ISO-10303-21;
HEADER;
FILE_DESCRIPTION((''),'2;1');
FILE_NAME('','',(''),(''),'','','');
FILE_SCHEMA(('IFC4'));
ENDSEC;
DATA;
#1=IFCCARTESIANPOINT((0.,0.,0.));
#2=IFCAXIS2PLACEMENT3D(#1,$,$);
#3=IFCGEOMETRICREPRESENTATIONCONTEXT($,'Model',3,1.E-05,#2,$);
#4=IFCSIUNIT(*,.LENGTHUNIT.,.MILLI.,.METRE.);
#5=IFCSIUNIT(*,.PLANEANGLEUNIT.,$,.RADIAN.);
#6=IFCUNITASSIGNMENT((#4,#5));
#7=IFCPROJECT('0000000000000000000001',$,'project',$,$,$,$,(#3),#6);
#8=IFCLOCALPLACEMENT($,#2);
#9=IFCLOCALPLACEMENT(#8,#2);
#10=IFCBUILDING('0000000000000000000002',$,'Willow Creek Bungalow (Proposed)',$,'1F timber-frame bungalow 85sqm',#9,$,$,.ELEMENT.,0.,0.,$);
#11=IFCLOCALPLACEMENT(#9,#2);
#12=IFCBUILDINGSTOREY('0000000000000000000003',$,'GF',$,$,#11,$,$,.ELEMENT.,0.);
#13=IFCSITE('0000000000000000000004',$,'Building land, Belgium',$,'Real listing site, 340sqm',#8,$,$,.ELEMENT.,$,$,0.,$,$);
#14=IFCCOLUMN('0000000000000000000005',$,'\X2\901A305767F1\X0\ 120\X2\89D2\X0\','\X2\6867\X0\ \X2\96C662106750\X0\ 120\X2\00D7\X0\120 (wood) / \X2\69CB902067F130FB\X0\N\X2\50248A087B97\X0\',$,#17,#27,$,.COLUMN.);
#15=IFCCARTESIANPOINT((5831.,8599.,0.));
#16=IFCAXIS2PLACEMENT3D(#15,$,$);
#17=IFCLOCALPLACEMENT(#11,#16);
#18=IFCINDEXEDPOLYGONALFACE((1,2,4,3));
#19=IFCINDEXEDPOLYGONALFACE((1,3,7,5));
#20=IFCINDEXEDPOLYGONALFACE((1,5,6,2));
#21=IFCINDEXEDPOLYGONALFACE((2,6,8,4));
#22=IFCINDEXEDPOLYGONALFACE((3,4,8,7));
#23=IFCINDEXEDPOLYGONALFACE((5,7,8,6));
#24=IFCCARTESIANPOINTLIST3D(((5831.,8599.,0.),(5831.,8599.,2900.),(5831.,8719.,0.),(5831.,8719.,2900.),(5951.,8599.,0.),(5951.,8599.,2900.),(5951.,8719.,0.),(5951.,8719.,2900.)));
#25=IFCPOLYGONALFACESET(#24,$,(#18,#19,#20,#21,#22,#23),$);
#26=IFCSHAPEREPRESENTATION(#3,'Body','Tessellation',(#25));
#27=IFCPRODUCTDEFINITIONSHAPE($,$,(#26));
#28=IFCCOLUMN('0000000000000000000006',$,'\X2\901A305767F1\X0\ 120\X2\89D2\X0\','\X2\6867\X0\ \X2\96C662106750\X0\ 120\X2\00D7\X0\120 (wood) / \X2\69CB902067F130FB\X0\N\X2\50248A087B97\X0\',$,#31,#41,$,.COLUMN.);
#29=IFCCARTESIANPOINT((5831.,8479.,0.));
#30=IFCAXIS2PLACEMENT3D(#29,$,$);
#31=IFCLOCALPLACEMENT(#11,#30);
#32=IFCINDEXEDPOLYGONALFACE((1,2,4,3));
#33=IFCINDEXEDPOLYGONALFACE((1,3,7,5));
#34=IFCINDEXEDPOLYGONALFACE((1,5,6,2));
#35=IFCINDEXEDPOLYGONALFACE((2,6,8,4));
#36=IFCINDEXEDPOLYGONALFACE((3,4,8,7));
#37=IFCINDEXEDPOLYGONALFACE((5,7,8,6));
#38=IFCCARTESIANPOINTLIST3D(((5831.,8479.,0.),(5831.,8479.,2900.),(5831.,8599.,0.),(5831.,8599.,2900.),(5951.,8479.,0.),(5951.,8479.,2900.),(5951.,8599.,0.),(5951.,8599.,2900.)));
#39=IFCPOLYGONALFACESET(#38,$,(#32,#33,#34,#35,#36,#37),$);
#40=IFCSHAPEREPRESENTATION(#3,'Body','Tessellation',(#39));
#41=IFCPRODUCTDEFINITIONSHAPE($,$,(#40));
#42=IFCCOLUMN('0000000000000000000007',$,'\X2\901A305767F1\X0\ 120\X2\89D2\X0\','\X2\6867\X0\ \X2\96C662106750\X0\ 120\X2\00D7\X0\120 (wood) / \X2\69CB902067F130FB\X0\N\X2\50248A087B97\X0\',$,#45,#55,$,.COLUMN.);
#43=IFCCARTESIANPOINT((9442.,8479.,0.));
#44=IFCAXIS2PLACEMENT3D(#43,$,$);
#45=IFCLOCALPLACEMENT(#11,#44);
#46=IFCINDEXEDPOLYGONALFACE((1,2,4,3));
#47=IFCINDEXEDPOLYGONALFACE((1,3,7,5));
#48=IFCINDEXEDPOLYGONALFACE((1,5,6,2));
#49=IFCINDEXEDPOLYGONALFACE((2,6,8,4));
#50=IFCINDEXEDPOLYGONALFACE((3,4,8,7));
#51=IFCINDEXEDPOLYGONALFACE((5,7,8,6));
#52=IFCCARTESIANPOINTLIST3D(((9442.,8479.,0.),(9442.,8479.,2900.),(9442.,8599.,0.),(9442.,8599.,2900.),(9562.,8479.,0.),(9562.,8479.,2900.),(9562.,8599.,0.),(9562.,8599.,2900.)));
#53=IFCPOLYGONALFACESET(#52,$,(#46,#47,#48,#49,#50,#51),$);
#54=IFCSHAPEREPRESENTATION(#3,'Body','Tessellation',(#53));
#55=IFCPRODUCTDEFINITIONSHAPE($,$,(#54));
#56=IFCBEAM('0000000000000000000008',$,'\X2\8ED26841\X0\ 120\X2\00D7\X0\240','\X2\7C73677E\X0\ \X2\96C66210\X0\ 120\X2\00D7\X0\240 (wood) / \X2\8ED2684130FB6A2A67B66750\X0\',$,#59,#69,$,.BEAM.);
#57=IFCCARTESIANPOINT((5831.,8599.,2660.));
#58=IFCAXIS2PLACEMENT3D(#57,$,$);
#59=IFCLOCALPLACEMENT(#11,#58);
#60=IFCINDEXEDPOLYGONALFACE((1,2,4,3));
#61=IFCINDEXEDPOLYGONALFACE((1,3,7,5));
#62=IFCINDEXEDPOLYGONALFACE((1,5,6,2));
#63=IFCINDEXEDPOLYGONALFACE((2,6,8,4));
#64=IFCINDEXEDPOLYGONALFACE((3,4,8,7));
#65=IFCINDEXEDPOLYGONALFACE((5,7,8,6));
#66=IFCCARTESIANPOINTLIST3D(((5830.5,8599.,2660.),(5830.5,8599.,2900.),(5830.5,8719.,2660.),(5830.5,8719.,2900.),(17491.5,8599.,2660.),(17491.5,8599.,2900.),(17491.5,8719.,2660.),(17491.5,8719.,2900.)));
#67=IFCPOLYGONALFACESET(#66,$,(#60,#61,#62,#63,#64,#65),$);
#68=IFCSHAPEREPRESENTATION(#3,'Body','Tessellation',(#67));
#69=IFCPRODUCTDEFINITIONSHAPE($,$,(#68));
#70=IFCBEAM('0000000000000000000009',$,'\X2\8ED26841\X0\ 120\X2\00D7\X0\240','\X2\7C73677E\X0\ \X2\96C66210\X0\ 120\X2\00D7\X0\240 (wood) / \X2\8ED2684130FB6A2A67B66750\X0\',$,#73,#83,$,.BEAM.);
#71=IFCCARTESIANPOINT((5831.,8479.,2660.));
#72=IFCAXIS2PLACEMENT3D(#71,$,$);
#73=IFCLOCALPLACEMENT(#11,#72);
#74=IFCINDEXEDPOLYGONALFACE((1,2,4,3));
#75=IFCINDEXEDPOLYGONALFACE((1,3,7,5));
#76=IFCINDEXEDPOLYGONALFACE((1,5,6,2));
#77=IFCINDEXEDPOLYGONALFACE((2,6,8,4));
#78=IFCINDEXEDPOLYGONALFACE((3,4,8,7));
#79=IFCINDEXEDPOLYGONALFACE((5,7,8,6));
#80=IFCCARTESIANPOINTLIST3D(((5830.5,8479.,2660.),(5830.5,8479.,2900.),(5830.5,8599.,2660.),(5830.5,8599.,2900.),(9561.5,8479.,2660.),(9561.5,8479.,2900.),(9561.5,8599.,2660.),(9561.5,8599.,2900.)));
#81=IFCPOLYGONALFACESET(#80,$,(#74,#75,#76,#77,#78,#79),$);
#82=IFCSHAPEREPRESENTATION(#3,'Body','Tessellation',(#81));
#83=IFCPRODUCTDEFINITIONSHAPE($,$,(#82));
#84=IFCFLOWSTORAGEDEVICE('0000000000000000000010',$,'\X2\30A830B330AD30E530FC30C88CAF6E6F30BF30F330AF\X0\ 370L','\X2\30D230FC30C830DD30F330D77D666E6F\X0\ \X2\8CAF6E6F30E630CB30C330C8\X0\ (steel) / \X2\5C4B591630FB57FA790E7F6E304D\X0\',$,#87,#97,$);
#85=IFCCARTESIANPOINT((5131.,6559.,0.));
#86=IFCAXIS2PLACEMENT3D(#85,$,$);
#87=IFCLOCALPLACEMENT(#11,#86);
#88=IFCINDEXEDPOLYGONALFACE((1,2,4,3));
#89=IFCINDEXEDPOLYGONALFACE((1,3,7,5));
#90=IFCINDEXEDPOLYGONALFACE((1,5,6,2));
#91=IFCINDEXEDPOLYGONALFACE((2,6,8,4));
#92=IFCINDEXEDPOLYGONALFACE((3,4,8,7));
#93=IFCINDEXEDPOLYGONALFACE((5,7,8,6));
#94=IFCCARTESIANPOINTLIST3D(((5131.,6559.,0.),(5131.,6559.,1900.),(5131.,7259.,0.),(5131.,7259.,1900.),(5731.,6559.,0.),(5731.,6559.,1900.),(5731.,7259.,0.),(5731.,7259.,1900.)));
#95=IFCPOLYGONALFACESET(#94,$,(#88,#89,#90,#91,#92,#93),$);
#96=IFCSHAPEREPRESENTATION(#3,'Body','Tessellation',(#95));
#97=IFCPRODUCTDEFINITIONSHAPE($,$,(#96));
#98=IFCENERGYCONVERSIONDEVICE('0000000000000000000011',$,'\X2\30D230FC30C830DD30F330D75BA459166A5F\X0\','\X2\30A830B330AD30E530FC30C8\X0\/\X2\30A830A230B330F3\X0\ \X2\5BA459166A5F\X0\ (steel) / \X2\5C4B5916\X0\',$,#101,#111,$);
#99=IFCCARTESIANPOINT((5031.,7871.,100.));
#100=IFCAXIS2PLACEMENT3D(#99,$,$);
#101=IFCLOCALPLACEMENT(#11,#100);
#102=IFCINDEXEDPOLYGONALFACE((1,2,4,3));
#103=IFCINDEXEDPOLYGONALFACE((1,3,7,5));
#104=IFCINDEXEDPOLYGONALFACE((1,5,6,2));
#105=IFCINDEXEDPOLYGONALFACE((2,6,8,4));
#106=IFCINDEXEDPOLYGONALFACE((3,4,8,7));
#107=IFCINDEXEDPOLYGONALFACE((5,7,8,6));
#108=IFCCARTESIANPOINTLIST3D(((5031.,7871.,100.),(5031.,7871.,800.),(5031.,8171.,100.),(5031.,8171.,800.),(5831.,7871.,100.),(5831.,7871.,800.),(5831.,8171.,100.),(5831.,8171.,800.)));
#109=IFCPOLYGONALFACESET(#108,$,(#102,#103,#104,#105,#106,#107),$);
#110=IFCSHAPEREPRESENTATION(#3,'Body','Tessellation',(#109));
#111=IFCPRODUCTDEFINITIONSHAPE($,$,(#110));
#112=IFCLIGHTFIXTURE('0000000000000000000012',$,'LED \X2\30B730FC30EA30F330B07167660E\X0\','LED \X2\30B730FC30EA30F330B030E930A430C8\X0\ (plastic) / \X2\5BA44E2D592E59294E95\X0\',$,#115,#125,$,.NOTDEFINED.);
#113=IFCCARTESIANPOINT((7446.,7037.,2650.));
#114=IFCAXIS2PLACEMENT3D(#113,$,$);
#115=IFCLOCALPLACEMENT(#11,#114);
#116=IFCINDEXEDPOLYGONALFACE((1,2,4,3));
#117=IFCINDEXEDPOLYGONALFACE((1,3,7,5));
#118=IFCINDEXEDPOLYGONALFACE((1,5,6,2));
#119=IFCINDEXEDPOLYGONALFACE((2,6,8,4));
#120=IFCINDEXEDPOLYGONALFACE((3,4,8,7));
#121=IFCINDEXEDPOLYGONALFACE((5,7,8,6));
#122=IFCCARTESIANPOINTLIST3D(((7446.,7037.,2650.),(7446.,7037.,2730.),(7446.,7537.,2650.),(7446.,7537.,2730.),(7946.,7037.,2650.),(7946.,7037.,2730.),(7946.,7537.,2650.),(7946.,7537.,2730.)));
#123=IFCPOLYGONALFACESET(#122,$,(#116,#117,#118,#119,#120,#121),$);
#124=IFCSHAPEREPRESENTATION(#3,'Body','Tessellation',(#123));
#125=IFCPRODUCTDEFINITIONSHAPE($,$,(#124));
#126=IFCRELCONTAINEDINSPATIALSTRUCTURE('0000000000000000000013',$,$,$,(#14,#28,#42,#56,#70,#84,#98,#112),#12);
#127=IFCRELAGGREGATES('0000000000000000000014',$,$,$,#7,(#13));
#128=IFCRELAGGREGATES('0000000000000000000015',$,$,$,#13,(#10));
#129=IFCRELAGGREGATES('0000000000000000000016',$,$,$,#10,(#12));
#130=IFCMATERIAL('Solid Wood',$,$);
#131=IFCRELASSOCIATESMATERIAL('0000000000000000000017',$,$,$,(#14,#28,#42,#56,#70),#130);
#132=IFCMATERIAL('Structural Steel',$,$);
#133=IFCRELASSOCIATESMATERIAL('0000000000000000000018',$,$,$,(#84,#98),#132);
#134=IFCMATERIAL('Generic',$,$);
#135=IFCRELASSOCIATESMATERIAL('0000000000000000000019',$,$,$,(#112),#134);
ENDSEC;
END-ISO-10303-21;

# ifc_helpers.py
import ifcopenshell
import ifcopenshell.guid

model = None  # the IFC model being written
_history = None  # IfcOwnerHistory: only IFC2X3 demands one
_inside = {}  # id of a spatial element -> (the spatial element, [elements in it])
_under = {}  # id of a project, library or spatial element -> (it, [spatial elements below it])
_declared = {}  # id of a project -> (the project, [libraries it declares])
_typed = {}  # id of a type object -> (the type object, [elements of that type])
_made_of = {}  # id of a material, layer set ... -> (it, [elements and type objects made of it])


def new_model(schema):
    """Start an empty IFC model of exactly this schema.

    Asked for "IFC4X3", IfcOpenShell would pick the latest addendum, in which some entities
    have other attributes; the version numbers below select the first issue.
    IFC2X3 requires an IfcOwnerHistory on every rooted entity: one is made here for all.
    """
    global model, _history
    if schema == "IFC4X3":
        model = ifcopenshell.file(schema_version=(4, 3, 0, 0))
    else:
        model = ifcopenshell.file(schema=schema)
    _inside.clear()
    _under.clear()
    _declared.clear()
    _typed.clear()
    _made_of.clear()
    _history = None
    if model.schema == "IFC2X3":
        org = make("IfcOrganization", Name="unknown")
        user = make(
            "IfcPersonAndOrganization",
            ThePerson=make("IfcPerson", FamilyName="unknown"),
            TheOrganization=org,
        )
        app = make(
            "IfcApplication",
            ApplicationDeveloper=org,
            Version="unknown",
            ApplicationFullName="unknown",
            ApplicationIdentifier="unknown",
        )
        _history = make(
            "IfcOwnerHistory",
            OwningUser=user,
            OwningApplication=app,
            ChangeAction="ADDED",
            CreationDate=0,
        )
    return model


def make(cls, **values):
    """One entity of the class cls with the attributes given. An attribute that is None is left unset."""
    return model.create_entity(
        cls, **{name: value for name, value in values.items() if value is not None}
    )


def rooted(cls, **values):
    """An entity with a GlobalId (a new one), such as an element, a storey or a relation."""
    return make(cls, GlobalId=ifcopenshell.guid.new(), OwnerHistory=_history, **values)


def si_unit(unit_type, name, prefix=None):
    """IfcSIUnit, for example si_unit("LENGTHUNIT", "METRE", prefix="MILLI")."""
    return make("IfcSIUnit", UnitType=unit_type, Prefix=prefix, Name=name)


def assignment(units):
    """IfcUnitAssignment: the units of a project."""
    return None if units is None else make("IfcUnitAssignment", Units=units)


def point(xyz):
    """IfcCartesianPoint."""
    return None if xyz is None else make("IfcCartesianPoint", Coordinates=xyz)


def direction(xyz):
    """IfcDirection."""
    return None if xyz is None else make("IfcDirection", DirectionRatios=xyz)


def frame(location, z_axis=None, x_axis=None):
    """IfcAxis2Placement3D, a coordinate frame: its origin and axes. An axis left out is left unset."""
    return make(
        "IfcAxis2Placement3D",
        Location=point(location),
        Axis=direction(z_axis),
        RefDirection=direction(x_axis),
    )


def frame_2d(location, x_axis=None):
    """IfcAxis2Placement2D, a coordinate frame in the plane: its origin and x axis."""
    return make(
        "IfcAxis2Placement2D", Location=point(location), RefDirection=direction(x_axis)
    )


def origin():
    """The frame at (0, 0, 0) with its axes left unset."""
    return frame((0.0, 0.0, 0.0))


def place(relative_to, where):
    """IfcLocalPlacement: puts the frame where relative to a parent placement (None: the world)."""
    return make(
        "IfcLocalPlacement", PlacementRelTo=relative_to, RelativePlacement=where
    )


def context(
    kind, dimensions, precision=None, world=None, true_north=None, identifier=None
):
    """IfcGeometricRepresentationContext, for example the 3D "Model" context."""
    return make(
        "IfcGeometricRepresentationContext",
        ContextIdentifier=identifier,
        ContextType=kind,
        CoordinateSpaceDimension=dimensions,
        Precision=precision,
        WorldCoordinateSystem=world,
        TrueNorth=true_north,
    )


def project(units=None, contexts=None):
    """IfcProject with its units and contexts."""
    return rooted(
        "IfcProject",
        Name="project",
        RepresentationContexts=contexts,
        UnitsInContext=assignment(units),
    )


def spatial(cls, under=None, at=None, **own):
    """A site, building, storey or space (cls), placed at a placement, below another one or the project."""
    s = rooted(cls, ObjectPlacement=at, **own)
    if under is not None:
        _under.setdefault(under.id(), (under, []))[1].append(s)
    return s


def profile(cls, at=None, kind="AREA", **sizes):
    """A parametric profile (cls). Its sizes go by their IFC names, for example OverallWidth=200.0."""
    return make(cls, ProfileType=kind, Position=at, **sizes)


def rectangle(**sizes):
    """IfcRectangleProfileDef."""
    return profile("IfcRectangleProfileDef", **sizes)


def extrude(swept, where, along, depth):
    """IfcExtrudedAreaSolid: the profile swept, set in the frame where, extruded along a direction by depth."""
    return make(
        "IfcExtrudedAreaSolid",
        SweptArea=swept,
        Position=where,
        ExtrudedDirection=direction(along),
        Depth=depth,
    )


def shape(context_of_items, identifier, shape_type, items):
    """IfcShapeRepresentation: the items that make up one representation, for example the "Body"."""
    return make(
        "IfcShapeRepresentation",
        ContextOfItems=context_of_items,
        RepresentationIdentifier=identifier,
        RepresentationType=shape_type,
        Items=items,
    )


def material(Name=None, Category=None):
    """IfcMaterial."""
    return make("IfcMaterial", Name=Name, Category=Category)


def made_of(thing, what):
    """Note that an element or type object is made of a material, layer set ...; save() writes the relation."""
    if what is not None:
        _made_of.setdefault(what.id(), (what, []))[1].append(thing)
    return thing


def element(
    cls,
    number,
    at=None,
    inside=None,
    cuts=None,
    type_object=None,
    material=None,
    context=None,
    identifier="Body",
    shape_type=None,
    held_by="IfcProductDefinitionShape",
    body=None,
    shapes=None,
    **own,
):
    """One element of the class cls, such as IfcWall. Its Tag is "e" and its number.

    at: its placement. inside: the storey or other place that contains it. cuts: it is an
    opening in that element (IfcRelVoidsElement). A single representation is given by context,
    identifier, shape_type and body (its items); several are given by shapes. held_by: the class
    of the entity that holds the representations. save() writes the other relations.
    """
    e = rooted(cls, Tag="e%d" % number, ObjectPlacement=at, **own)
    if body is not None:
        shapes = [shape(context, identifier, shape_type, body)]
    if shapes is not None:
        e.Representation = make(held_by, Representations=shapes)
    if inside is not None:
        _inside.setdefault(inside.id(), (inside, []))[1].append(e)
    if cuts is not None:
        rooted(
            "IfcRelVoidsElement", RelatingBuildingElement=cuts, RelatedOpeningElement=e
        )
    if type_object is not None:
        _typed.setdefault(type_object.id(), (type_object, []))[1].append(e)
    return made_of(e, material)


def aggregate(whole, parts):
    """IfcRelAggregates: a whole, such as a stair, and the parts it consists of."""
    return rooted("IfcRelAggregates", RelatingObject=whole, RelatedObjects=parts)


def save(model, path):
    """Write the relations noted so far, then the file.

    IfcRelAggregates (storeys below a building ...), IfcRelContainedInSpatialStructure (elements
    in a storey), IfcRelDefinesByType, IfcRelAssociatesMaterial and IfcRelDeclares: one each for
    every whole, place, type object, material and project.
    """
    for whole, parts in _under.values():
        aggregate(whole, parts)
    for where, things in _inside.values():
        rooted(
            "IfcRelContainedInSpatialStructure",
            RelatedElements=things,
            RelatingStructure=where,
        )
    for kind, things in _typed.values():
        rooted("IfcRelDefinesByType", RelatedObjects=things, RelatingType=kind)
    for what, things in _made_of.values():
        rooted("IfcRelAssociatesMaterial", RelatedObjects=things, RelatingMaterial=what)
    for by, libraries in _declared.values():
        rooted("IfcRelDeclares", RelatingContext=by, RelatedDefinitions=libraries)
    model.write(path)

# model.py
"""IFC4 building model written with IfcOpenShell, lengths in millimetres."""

from ifc_helpers import new_model, si_unit, frame, frame_2d, origin, place, context, project, spatial, rectangle, extrude, material, element, save


model = new_model("IFC4")

# Units and contexts
model_context = context("Model", 3, precision=1e-05, world=origin())
ifc_project = project(units=[si_unit("LENGTHUNIT", "METRE", prefix="MILLI"), si_unit("PLANEANGLEUNIT", "RADIAN")], contexts=[model_context])

# Site, building, storey
site_placement = place(None, origin())
site = spatial("IfcSite", under=ifc_project, at=site_placement, Name="Building land, Belgium", ObjectType="Real listing site, 340sqm", CompositionType="ELEMENT", RefElevation=0.0)
building_placement = place(site_placement, origin())
building = spatial("IfcBuilding", under=site, at=building_placement, Name="Willow Creek Bungalow (Proposed)", ObjectType="1F timber-frame bungalow 85sqm", CompositionType="ELEMENT", ElevationOfRefHeight=0.0, ElevationOfTerrain=0.0)
storey_placement = place(building_placement, origin())
storey = spatial("IfcBuildingStorey", under=building, at=storey_placement, Name="GF", CompositionType="ELEMENT", Elevation=0.0)

# Columns
ifc_material_1 = material(Name="Solid Wood")
column_1_placement = place(storey_placement, frame((5831.0, 8599.0, 0.0)))
element("IfcColumn", 1, at=column_1_placement, inside=storey, material=ifc_material_1, Name="通し柱 120角", Description="桧 集成材 120×120 (wood) / 構造柱・N値計算", PredefinedType="COLUMN", context=model_context, shape_type="SweptSolid", body=[
    extrude(rectangle(XDim=120.0, YDim=120.0, at=frame_2d((60.0, 60.0))), frame((5831.0, 8599.0, 0.0)), (0.0, 0.0, 1.0), 2900.0),
])
column_2_placement = place(storey_placement, frame((5831.0, 8479.0, 0.0)))
element("IfcColumn", 2, at=column_2_placement, inside=storey, material=ifc_material_1, Name="通し柱 120角", Description="桧 集成材 120×120 (wood) / 構造柱・N値計算", PredefinedType="COLUMN", context=model_context, shape_type="SweptSolid", body=[
    extrude(rectangle(XDim=120.0, YDim=120.0, at=frame_2d((60.0, 60.0))), frame((5831.0, 8479.0, 0.0)), (0.0, 0.0, 1.0), 2900.0),
])
column_3_placement = place(storey_placement, frame((9442.0, 8479.0, 0.0)))
element("IfcColumn", 3, at=column_3_placement, inside=storey, material=ifc_material_1, Name="通し柱 120角", Description="桧 集成材 120×120 (wood) / 構造柱・N値計算", PredefinedType="COLUMN", context=model_context, shape_type="SweptSolid", body=[
    extrude(rectangle(XDim=120.0, YDim=120.0, at=frame_2d((60.0, 60.0))), frame((9442.0, 8479.0, 0.0)), (0.0, 0.0, 1.0), 2900.0),
])

# Beams
beam_1_placement = place(storey_placement, frame((5831.0, 8599.0, 2660.0)))
element("IfcBeam", 4, at=beam_1_placement, inside=storey, material=ifc_material_1, Name="軒桁 120×240", Description="米松 集成 120×240 (wood) / 軒桁・横架材", PredefinedType="BEAM", context=model_context, shape_type="SweptSolid", body=[
    extrude(rectangle(XDim=11661.0, YDim=120.0, at=frame_2d((5830.0, 60.0))), frame((5831.0, 8599.0, 2660.0)), (0.0, 0.0, 1.0), 240.0),
])
beam_2_placement = place(storey_placement, frame((5831.0, 8479.0, 2660.0)))
element("IfcBeam", 5, at=beam_2_placement, inside=storey, material=ifc_material_1, Name="軒桁 120×240", Description="米松 集成 120×240 (wood) / 軒桁・横架材", PredefinedType="BEAM", context=model_context, shape_type="SweptSolid", body=[
    extrude(rectangle(XDim=3731.0, YDim=120.0, at=frame_2d((1865.0, 60.0))), frame((5831.0, 8479.0, 2660.0)), (0.0, 0.0, 1.0), 240.0),
])

# Shared definitions
ifc_material_2 = material(Name="Structural Steel")

# Shared definitions
ifc_material_3 = material(Name="Generic")

# Flow storage device
flow_storage_device_placement = place(storey_placement, frame((5131.0, 6559.0, 0.0)))
element("IfcFlowStorageDevice", 6, at=flow_storage_device_placement, inside=storey, material=ifc_material_2, Name="エコキュート貯湯タンク 370L", Description="ヒートポンプ給湯 貯湯ユニット (steel) / 屋外・基礎置き", context=model_context, shape_type="SweptSolid", body=[
    extrude(rectangle(XDim=600.0, YDim=700.0, at=frame_2d((300.0, 350.0))), frame((5131.0, 6559.0, 0.0)), (0.0, 0.0, 1.0), 1900.0),
])

# Energy conversion device
energy_conversion_device_placement = place(storey_placement, frame((5031.0, 7871.0, 100.0)))
element("IfcEnergyConversionDevice", 7, at=energy_conversion_device_placement, inside=storey, material=ifc_material_2, Name="ヒートポンプ室外機", Description="エコキュート/エアコン 室外機 (steel) / 屋外", context=model_context, shape_type="SweptSolid", body=[
    extrude(rectangle(XDim=800.0, YDim=300.0, at=frame_2d((400.0, 150.0))), frame((5031.0, 7871.0, 100.0)), (0.0, 0.0, 1.0), 700.0),
])

# Light fixture
light_fixture_placement = place(storey_placement, frame((7446.0, 7037.0, 2650.0)))
element("IfcLightFixture", 8, at=light_fixture_placement, inside=storey, material=ifc_material_3, Name="LED シーリング照明", Description="LED シーリングライト (plastic) / 室中央天井", PredefinedType="NOTDEFINED", context=model_context, shape_type="SweptSolid", body=[
    extrude(rectangle(XDim=500.0, YDim=500.0, at=frame_2d((250.0, 250.0))), frame((7446.0, 7037.0, 2650.0)), (0.0, 0.0, 1.0), 80.0),
])

save(model, "model.ifc")
